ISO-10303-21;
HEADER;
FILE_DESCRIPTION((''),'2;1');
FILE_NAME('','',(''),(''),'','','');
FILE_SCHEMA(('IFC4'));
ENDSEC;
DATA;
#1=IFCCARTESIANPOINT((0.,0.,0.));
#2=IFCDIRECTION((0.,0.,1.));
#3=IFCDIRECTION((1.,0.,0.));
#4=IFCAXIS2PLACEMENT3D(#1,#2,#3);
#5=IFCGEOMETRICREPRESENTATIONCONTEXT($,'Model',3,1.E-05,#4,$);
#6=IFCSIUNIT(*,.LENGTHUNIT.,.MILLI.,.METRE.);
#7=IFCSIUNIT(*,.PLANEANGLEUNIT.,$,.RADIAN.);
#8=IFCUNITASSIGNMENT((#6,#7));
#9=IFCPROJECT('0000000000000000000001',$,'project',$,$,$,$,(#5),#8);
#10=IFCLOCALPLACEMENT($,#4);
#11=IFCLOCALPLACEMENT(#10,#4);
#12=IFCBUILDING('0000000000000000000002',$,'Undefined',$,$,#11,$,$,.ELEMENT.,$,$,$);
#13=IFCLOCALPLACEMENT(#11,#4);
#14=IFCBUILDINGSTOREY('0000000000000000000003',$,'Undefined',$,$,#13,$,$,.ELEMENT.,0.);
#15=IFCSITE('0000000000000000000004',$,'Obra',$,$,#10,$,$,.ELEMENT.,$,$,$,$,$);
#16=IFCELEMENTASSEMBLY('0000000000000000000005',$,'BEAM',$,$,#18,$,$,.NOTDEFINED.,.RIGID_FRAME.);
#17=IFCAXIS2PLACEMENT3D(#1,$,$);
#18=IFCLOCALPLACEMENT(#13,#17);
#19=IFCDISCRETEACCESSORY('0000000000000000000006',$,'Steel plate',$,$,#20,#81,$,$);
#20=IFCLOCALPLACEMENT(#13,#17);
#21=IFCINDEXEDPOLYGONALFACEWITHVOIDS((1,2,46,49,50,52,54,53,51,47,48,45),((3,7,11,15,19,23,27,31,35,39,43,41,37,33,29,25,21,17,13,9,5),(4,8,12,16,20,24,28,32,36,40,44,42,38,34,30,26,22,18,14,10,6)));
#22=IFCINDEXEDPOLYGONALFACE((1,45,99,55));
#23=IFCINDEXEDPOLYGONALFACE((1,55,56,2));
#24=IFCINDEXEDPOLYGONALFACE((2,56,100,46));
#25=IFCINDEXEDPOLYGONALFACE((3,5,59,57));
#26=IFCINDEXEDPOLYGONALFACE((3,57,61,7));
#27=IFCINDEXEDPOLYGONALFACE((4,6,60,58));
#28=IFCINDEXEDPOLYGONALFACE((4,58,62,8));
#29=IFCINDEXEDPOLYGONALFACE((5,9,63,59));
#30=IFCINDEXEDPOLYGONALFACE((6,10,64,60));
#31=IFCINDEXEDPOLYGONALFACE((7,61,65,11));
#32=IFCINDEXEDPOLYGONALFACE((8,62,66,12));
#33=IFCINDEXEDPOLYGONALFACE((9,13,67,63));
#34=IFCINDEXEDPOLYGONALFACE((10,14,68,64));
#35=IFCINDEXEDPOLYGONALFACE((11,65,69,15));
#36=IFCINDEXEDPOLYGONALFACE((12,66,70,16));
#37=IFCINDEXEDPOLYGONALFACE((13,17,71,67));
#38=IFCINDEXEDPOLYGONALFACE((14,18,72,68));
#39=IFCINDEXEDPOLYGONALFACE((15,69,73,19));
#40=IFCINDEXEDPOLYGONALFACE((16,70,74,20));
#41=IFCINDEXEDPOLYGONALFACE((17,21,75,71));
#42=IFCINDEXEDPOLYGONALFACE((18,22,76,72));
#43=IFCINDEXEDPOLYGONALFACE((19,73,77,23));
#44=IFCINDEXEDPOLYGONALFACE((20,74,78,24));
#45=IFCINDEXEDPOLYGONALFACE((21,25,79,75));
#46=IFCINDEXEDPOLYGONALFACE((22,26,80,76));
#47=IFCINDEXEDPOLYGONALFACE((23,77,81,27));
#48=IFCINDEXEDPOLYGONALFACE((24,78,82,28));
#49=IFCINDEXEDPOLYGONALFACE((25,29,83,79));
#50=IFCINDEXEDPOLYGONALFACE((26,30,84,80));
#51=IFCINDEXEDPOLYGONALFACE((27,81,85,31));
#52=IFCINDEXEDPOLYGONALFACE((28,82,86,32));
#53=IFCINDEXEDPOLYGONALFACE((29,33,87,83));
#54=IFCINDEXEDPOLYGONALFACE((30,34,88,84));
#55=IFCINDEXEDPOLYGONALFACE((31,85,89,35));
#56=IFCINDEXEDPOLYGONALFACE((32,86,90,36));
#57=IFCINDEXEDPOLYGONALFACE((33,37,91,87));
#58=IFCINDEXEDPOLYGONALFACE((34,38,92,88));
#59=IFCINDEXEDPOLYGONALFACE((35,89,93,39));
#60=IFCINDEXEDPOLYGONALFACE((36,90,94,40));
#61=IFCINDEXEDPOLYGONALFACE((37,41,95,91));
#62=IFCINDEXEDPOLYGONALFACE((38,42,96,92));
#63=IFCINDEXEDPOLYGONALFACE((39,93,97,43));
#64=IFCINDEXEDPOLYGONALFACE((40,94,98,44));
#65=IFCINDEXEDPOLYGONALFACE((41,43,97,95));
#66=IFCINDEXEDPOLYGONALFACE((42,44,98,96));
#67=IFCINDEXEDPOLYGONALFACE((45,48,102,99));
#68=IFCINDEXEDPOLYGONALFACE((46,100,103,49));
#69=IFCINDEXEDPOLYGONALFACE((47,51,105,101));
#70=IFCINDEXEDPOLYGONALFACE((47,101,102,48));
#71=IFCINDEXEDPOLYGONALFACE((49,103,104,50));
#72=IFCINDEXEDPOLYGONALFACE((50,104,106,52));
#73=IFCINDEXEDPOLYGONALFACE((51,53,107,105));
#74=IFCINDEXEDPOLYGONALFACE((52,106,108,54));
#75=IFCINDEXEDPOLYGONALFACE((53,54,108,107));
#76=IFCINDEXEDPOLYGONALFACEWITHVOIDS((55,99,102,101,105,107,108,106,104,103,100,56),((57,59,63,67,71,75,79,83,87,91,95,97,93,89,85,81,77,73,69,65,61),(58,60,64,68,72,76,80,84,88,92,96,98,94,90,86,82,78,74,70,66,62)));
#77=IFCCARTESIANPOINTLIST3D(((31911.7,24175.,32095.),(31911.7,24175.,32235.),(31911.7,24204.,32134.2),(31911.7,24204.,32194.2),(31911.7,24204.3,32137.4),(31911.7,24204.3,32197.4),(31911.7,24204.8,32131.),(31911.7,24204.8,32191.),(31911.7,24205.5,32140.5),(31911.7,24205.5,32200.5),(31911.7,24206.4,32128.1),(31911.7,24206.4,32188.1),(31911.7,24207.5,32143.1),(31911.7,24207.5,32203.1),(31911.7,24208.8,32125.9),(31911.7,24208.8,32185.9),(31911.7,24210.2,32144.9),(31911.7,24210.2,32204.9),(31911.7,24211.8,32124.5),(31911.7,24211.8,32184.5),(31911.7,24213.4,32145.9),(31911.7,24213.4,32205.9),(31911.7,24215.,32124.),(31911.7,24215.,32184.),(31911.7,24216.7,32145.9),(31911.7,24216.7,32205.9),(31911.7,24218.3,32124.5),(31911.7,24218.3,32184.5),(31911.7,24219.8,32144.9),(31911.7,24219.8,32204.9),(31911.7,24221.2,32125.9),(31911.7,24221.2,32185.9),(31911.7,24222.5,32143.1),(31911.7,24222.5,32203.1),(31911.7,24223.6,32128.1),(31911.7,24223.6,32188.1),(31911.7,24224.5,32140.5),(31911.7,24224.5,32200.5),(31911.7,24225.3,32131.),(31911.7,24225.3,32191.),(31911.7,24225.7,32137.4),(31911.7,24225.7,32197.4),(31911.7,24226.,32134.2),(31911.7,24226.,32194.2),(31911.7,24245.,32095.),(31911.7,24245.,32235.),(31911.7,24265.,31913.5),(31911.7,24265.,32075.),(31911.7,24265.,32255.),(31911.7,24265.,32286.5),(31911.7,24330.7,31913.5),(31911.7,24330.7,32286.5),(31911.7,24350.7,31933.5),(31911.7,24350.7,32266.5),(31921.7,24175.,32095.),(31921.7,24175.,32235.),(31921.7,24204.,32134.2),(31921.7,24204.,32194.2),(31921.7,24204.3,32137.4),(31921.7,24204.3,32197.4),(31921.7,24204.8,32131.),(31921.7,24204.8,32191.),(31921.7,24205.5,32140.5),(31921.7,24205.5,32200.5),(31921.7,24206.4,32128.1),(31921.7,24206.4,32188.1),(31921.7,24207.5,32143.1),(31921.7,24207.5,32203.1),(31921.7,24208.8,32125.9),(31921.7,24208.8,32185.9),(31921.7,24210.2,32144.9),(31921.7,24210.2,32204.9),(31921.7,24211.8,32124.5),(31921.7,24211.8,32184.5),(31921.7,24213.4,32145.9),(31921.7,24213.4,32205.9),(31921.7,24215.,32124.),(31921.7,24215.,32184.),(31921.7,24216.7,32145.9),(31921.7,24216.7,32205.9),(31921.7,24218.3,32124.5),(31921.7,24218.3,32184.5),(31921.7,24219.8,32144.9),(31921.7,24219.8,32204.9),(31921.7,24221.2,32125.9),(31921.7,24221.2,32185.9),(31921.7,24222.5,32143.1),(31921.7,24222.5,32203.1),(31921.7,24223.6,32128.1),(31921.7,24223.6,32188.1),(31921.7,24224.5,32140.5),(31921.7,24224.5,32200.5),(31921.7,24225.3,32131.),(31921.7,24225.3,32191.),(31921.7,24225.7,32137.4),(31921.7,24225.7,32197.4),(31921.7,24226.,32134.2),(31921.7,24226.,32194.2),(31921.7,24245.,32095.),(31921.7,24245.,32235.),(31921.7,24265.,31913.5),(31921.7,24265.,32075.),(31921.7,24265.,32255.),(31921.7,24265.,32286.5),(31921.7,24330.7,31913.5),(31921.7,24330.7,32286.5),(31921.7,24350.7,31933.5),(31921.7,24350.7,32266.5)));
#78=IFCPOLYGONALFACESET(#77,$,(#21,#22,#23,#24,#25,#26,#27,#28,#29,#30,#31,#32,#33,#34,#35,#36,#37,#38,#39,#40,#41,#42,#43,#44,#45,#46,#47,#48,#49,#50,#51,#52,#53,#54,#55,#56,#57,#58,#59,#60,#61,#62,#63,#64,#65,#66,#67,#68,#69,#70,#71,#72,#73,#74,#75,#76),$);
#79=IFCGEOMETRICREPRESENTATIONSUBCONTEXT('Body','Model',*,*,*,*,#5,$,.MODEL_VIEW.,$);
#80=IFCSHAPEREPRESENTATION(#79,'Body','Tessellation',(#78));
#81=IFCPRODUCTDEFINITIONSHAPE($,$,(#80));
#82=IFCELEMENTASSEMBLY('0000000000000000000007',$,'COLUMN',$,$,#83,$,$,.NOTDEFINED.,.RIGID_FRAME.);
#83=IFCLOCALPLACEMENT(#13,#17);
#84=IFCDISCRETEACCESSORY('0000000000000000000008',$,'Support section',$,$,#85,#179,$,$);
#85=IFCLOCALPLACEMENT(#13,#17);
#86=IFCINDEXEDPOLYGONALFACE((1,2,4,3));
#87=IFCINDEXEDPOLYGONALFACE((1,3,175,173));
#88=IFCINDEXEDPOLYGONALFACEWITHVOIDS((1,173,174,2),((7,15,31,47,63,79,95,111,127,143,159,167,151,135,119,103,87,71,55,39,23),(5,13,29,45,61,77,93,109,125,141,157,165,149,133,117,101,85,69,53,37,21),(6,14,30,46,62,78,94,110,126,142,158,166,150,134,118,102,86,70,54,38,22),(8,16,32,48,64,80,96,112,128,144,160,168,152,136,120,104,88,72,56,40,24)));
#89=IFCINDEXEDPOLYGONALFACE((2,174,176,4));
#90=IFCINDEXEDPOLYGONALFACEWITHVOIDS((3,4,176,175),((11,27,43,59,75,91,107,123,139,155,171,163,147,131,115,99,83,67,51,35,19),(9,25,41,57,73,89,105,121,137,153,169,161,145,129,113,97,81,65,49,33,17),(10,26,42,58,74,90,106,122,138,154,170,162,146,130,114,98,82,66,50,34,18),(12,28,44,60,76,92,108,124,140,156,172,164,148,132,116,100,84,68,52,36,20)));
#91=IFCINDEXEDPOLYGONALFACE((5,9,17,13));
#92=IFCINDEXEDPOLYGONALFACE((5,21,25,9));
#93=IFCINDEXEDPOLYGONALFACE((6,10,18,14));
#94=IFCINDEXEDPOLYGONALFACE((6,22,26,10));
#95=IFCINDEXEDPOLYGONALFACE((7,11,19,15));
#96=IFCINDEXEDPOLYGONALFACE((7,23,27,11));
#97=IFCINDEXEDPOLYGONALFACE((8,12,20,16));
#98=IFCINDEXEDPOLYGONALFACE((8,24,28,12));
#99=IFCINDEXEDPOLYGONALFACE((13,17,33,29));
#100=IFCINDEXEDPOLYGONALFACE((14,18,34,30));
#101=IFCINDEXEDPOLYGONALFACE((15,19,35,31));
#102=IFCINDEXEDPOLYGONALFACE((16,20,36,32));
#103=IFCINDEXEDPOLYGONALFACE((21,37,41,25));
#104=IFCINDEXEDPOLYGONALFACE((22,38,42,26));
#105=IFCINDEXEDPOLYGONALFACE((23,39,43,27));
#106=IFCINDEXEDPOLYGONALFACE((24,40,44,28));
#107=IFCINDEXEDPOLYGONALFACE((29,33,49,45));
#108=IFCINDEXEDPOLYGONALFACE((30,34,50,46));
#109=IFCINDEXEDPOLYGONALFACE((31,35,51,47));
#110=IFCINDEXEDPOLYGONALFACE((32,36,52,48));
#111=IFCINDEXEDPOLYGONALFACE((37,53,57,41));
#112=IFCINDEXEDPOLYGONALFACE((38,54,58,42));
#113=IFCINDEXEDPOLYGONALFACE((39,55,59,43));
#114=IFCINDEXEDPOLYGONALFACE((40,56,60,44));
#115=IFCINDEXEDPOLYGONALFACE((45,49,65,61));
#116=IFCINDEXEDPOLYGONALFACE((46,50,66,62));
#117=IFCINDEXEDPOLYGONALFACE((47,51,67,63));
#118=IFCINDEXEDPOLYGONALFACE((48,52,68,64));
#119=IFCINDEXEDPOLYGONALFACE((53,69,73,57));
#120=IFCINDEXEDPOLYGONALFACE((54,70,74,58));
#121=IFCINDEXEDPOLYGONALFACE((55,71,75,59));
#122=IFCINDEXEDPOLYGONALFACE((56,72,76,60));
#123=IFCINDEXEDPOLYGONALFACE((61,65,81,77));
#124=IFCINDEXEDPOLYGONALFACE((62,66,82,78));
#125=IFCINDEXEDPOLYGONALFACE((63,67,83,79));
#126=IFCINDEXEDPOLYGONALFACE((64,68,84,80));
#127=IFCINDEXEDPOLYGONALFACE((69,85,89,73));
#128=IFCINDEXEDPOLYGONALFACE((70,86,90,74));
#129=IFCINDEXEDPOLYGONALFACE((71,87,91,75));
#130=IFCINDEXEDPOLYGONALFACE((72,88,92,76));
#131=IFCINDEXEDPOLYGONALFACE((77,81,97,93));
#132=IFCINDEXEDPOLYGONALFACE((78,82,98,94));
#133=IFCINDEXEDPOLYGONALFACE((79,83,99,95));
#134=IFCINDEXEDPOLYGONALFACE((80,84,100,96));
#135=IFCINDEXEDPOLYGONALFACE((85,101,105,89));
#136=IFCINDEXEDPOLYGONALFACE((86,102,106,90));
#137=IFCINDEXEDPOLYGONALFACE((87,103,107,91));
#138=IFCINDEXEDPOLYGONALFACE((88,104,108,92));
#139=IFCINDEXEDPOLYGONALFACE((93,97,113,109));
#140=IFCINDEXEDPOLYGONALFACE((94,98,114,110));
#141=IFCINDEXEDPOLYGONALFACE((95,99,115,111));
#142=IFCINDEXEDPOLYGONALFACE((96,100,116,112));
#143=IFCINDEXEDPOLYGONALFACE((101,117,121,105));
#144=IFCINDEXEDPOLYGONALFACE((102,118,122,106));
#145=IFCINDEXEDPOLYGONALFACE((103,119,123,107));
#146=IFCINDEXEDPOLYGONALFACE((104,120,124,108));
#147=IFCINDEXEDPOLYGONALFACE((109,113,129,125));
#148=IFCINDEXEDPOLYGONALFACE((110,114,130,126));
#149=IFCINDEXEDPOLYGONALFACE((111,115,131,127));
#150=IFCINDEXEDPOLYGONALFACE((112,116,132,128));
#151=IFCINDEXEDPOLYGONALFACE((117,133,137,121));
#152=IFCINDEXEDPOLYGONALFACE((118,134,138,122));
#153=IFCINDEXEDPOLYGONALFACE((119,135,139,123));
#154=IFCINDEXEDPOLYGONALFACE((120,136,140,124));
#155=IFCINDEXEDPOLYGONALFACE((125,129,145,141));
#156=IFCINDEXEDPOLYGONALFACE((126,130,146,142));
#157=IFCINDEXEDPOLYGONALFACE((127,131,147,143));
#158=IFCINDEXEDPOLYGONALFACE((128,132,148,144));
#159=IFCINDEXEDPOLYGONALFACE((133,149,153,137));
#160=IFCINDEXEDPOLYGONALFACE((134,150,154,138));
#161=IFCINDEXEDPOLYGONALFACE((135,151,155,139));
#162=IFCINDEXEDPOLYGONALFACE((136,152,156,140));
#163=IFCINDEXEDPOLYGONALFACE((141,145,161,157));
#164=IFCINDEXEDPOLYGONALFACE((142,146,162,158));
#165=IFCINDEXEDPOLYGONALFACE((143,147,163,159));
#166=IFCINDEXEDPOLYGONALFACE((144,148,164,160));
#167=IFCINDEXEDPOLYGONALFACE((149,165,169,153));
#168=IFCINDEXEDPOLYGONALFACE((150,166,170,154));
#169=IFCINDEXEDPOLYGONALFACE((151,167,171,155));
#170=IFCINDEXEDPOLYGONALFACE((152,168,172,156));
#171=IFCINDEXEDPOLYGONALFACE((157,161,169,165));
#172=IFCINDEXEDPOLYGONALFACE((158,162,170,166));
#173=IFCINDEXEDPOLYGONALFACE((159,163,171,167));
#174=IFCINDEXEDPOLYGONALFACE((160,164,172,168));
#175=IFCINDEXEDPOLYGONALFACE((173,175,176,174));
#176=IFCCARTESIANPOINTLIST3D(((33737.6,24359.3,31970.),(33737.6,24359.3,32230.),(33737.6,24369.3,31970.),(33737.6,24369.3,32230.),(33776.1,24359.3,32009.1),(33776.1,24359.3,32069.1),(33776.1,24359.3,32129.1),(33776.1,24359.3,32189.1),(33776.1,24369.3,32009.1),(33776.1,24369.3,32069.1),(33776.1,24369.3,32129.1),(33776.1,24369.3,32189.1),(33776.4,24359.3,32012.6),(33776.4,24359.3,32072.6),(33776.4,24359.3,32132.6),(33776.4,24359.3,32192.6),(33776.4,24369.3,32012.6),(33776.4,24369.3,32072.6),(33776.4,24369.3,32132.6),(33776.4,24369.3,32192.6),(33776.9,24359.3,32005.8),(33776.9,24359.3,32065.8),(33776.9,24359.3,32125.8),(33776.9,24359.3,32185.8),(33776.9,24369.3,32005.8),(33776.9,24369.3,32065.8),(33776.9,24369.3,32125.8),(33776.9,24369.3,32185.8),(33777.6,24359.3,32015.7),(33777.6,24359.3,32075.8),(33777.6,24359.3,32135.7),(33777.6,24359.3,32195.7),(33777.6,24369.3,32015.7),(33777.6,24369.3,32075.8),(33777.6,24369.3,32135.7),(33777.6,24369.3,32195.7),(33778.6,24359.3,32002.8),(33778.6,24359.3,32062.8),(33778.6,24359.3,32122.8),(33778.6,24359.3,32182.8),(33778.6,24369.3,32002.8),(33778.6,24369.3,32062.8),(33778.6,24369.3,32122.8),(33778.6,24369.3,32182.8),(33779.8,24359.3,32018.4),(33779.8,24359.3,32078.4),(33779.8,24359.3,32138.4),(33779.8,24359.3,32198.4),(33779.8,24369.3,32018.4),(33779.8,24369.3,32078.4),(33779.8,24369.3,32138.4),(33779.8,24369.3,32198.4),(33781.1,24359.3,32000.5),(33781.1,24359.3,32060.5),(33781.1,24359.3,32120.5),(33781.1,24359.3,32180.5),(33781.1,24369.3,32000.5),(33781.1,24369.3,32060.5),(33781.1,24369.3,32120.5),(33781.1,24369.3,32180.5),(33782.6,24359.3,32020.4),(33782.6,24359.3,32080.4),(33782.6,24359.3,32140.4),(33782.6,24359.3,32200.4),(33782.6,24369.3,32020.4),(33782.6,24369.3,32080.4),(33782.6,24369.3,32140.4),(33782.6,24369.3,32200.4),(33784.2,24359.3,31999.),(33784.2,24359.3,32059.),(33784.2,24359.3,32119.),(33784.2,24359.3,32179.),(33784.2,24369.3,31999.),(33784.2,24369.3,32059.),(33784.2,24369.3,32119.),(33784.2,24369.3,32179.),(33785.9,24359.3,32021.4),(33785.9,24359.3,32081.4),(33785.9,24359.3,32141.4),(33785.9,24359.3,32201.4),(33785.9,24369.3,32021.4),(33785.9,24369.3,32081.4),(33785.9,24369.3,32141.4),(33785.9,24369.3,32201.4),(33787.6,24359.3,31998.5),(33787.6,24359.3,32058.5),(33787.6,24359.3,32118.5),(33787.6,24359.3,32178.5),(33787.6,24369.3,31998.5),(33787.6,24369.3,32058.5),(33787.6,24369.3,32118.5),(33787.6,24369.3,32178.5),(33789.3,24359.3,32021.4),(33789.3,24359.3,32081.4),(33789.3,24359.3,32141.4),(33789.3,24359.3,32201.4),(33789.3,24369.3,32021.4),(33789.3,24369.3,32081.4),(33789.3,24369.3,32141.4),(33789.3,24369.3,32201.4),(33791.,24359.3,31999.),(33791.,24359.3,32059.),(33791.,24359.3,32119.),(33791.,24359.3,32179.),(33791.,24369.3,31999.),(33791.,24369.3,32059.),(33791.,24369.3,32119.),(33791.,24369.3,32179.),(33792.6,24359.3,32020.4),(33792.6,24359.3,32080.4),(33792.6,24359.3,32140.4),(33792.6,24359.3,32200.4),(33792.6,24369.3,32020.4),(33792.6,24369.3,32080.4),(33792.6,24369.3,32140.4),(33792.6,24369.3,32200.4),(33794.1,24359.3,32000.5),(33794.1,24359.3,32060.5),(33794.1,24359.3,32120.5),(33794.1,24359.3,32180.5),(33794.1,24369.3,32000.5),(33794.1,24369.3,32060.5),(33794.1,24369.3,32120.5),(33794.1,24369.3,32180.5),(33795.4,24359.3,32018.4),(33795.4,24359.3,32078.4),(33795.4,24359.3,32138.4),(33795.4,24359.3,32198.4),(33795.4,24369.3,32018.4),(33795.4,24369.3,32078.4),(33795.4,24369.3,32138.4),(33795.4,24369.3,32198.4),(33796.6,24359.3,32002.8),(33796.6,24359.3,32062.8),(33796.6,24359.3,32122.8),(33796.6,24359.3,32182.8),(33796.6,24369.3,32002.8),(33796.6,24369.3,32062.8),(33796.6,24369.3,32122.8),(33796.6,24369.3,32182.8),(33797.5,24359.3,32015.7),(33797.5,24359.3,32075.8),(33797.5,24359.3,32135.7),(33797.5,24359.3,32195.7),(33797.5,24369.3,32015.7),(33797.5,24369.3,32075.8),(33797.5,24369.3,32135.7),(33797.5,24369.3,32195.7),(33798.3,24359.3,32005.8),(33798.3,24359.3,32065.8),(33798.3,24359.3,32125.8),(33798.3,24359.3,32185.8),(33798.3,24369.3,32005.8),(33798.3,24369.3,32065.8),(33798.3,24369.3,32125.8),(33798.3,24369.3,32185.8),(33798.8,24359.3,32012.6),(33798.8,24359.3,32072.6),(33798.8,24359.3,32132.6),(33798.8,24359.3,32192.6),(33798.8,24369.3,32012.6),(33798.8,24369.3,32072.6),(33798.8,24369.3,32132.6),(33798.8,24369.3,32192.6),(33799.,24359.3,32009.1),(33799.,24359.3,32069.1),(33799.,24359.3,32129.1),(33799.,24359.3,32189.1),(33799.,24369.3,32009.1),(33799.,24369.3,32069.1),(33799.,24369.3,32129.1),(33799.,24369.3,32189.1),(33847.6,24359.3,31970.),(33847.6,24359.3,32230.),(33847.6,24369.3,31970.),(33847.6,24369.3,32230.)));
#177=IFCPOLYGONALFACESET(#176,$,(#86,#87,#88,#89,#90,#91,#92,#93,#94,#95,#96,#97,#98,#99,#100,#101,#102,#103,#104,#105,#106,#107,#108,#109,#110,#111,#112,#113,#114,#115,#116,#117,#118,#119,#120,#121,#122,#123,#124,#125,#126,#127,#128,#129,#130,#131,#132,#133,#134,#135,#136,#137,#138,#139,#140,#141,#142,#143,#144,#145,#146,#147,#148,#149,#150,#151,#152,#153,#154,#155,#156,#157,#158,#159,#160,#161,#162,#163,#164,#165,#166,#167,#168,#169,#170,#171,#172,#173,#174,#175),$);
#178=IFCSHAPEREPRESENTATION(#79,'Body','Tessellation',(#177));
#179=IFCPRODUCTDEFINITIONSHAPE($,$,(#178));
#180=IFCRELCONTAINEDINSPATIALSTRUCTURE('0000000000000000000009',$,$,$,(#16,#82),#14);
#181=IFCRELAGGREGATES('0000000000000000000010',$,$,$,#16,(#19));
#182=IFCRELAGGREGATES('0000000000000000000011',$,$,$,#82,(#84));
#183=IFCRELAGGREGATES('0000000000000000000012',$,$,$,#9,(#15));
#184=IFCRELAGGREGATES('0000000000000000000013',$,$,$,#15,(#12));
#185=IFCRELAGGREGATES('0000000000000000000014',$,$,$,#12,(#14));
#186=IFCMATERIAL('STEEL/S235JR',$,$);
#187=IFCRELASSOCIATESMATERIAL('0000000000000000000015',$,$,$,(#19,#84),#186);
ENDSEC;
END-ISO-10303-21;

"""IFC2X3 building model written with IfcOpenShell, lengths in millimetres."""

from ifc_helpers import new_model, si_unit, frame, origin_with_axes, origin_2d_with_axis, place, context, subcontext, project, spatial, polyline, rectangle, circle, outline, extrude, source, transform, mapped, material, element, aggregate, save


model = new_model("IFC2X3")

# Units and contexts
model_context = context("Model", 3, precision=1e-05, world=origin_with_axes())
body_context = subcontext(model_context, "Body", "Model", "MODEL_VIEW")
ifc_project = project(units=[si_unit("LENGTHUNIT", "METRE", prefix="MILLI"), si_unit("PLANEANGLEUNIT", "RADIAN")], contexts=[model_context])

# Site, building, storey
site_placement = place(None, origin_with_axes())
site = spatial("IfcSite", under=ifc_project, at=site_placement, Name="Obra", CompositionType="ELEMENT")
building_placement = place(site_placement, origin_with_axes())
building = spatial("IfcBuilding", under=site, at=building_placement, Name="Undefined", CompositionType="ELEMENT")
storey_placement = place(building_placement, origin_with_axes())
storey = spatial("IfcBuildingStorey", under=building, at=storey_placement, Name="Undefined", CompositionType="ELEMENT", Elevation=0.0)

# Shared definitions
ifc_material_1 = material(Name="STEEL/S235JR")

# Element assembly
assembly_1_placement = place(storey_placement, origin_with_axes())
assembly_1 = element("IfcElementAssembly", 1, at=assembly_1_placement, inside=storey, Name="BEAM", AssemblyPlace="NOTDEFINED", PredefinedType="RIGID_FRAME")

# Discrete accessory, opening
discrete_accessory_1_placement = place(assembly_1_placement, frame((31916.7, 24350.7, 31933.5), z_axis=(-1.0, -0.000001, 0.0), x_axis=(0.000001, -0.707107, -0.707107)))
discrete_accessory_1 = element("IfcDiscreteAccessory", 2, at=discrete_accessory_1_placement, material=ifc_material_1, Name="Steel plate", context=body_context, shape_type="SweptSolid", body=[
    extrude(outline(polyline([(0.0, 0.0), (28.3, 0.0), (74.7, 46.5), (-39.5, 160.7), (-39.5, 188.9), (10.0, 238.4), (-89.0, 337.4), (-138.5, 287.9), (-166.7, 287.9), (-189.0, 310.2), (-235.5, 263.8), (-235.5, 235.5), (0.0, 0.0)])), frame((0.0, 0.0, -5.0), z_axis=(0.0, 0.0, 1.0), x_axis=(1.0, 0.0, 0.0)), (0.0, 0.0, 1.0), 10.0),
])
shared_shape_1 = source(origin_with_axes(), body_context, "Body", "SweptSolid", [
    extrude(circle(Radius=11.0, at=origin_2d_with_axis()), frame((0.0, -13.4, 0.0), z_axis=(0.0, 1.0, 0.0), x_axis=(1.0, 0.0, 0.0)), (0.0, 0.0, 1.0), 10.2),
])
opening_1_placement = place(assembly_1_placement, frame((31925.0, 24255.0, 32235.0), z_axis=(0.000001, -1.0, 0.0), x_axis=(0.0, 0.0, -1.0)))
element("IfcOpeningElement", 3, at=opening_1_placement, cuts=discrete_accessory_1, ObjectType="Opening", context=body_context, shape_type="MappedRepresentation", body=[
    mapped(shared_shape_1, transform((40.0, 0.0, 40.0))),
    mapped(shared_shape_1, transform((100.0, 0.0, 40.0))),
])
aggregate(assembly_1, [discrete_accessory_1])

# Element assembly, discrete accessory, opening
assembly_2_placement = place(storey_placement, origin_with_axes())
assembly_2 = element("IfcElementAssembly", 4, at=assembly_2_placement, inside=storey, Name="COLUMN", AssemblyPlace="NOTDEFINED", PredefinedType="RIGID_FRAME")
discrete_accessory_2_placement = place(assembly_2_placement, frame((33792.6, 24364.3, 31970.0), z_axis=(0.0, 0.0, 1.0), x_axis=(1.0, 0.0, 0.0)))
discrete_accessory_2 = element("IfcDiscreteAccessory", 5, at=discrete_accessory_2_placement, material=ifc_material_1, Name="Support section", context=body_context, shape_type="SweptSolid", body=[
    extrude(rectangle(XDim=10.0, YDim=110.0, at=origin_2d_with_axis()), frame((0.0, 0.0, 260.0), z_axis=(0.0, 0.0, -1.0), x_axis=(0.0, 1.0, 0.0)), (0.0, 0.0, 1.0), 260.0),
])
shared_shape_2 = source(origin_with_axes(), body_context, "Body", "SweptSolid", [
    extrude(circle(Radius=11.5, at=origin_2d_with_axis()), frame((0.0, -14.4, 0.0), z_axis=(0.0, 1.0, 0.0), x_axis=(1.0, 0.0, 0.0)), (0.0, 0.0, 1.0), 10.2),
])
opening_2_placement = place(assembly_2_placement, frame((33837.6, 24355.0, 32300.0), z_axis=(-1.0, 0.0, 0.0), x_axis=(0.0, 0.0, -1.0)))
element("IfcOpeningElement", 6, at=opening_2_placement, cuts=discrete_accessory_2, ObjectType="Opening", context=body_context, shape_type="MappedRepresentation", body=[
    mapped(shared_shape_2, transform((110.0, 0.0, 50.0))),
    mapped(shared_shape_2, transform((170.0, 0.0, 50.0))),
    mapped(shared_shape_2, transform((230.0, 0.0, 50.0))),
    mapped(shared_shape_2, transform((290.0, 0.0, 50.0))),
])
aggregate(assembly_2, [discrete_accessory_2])

save(model, "model.ifc")
